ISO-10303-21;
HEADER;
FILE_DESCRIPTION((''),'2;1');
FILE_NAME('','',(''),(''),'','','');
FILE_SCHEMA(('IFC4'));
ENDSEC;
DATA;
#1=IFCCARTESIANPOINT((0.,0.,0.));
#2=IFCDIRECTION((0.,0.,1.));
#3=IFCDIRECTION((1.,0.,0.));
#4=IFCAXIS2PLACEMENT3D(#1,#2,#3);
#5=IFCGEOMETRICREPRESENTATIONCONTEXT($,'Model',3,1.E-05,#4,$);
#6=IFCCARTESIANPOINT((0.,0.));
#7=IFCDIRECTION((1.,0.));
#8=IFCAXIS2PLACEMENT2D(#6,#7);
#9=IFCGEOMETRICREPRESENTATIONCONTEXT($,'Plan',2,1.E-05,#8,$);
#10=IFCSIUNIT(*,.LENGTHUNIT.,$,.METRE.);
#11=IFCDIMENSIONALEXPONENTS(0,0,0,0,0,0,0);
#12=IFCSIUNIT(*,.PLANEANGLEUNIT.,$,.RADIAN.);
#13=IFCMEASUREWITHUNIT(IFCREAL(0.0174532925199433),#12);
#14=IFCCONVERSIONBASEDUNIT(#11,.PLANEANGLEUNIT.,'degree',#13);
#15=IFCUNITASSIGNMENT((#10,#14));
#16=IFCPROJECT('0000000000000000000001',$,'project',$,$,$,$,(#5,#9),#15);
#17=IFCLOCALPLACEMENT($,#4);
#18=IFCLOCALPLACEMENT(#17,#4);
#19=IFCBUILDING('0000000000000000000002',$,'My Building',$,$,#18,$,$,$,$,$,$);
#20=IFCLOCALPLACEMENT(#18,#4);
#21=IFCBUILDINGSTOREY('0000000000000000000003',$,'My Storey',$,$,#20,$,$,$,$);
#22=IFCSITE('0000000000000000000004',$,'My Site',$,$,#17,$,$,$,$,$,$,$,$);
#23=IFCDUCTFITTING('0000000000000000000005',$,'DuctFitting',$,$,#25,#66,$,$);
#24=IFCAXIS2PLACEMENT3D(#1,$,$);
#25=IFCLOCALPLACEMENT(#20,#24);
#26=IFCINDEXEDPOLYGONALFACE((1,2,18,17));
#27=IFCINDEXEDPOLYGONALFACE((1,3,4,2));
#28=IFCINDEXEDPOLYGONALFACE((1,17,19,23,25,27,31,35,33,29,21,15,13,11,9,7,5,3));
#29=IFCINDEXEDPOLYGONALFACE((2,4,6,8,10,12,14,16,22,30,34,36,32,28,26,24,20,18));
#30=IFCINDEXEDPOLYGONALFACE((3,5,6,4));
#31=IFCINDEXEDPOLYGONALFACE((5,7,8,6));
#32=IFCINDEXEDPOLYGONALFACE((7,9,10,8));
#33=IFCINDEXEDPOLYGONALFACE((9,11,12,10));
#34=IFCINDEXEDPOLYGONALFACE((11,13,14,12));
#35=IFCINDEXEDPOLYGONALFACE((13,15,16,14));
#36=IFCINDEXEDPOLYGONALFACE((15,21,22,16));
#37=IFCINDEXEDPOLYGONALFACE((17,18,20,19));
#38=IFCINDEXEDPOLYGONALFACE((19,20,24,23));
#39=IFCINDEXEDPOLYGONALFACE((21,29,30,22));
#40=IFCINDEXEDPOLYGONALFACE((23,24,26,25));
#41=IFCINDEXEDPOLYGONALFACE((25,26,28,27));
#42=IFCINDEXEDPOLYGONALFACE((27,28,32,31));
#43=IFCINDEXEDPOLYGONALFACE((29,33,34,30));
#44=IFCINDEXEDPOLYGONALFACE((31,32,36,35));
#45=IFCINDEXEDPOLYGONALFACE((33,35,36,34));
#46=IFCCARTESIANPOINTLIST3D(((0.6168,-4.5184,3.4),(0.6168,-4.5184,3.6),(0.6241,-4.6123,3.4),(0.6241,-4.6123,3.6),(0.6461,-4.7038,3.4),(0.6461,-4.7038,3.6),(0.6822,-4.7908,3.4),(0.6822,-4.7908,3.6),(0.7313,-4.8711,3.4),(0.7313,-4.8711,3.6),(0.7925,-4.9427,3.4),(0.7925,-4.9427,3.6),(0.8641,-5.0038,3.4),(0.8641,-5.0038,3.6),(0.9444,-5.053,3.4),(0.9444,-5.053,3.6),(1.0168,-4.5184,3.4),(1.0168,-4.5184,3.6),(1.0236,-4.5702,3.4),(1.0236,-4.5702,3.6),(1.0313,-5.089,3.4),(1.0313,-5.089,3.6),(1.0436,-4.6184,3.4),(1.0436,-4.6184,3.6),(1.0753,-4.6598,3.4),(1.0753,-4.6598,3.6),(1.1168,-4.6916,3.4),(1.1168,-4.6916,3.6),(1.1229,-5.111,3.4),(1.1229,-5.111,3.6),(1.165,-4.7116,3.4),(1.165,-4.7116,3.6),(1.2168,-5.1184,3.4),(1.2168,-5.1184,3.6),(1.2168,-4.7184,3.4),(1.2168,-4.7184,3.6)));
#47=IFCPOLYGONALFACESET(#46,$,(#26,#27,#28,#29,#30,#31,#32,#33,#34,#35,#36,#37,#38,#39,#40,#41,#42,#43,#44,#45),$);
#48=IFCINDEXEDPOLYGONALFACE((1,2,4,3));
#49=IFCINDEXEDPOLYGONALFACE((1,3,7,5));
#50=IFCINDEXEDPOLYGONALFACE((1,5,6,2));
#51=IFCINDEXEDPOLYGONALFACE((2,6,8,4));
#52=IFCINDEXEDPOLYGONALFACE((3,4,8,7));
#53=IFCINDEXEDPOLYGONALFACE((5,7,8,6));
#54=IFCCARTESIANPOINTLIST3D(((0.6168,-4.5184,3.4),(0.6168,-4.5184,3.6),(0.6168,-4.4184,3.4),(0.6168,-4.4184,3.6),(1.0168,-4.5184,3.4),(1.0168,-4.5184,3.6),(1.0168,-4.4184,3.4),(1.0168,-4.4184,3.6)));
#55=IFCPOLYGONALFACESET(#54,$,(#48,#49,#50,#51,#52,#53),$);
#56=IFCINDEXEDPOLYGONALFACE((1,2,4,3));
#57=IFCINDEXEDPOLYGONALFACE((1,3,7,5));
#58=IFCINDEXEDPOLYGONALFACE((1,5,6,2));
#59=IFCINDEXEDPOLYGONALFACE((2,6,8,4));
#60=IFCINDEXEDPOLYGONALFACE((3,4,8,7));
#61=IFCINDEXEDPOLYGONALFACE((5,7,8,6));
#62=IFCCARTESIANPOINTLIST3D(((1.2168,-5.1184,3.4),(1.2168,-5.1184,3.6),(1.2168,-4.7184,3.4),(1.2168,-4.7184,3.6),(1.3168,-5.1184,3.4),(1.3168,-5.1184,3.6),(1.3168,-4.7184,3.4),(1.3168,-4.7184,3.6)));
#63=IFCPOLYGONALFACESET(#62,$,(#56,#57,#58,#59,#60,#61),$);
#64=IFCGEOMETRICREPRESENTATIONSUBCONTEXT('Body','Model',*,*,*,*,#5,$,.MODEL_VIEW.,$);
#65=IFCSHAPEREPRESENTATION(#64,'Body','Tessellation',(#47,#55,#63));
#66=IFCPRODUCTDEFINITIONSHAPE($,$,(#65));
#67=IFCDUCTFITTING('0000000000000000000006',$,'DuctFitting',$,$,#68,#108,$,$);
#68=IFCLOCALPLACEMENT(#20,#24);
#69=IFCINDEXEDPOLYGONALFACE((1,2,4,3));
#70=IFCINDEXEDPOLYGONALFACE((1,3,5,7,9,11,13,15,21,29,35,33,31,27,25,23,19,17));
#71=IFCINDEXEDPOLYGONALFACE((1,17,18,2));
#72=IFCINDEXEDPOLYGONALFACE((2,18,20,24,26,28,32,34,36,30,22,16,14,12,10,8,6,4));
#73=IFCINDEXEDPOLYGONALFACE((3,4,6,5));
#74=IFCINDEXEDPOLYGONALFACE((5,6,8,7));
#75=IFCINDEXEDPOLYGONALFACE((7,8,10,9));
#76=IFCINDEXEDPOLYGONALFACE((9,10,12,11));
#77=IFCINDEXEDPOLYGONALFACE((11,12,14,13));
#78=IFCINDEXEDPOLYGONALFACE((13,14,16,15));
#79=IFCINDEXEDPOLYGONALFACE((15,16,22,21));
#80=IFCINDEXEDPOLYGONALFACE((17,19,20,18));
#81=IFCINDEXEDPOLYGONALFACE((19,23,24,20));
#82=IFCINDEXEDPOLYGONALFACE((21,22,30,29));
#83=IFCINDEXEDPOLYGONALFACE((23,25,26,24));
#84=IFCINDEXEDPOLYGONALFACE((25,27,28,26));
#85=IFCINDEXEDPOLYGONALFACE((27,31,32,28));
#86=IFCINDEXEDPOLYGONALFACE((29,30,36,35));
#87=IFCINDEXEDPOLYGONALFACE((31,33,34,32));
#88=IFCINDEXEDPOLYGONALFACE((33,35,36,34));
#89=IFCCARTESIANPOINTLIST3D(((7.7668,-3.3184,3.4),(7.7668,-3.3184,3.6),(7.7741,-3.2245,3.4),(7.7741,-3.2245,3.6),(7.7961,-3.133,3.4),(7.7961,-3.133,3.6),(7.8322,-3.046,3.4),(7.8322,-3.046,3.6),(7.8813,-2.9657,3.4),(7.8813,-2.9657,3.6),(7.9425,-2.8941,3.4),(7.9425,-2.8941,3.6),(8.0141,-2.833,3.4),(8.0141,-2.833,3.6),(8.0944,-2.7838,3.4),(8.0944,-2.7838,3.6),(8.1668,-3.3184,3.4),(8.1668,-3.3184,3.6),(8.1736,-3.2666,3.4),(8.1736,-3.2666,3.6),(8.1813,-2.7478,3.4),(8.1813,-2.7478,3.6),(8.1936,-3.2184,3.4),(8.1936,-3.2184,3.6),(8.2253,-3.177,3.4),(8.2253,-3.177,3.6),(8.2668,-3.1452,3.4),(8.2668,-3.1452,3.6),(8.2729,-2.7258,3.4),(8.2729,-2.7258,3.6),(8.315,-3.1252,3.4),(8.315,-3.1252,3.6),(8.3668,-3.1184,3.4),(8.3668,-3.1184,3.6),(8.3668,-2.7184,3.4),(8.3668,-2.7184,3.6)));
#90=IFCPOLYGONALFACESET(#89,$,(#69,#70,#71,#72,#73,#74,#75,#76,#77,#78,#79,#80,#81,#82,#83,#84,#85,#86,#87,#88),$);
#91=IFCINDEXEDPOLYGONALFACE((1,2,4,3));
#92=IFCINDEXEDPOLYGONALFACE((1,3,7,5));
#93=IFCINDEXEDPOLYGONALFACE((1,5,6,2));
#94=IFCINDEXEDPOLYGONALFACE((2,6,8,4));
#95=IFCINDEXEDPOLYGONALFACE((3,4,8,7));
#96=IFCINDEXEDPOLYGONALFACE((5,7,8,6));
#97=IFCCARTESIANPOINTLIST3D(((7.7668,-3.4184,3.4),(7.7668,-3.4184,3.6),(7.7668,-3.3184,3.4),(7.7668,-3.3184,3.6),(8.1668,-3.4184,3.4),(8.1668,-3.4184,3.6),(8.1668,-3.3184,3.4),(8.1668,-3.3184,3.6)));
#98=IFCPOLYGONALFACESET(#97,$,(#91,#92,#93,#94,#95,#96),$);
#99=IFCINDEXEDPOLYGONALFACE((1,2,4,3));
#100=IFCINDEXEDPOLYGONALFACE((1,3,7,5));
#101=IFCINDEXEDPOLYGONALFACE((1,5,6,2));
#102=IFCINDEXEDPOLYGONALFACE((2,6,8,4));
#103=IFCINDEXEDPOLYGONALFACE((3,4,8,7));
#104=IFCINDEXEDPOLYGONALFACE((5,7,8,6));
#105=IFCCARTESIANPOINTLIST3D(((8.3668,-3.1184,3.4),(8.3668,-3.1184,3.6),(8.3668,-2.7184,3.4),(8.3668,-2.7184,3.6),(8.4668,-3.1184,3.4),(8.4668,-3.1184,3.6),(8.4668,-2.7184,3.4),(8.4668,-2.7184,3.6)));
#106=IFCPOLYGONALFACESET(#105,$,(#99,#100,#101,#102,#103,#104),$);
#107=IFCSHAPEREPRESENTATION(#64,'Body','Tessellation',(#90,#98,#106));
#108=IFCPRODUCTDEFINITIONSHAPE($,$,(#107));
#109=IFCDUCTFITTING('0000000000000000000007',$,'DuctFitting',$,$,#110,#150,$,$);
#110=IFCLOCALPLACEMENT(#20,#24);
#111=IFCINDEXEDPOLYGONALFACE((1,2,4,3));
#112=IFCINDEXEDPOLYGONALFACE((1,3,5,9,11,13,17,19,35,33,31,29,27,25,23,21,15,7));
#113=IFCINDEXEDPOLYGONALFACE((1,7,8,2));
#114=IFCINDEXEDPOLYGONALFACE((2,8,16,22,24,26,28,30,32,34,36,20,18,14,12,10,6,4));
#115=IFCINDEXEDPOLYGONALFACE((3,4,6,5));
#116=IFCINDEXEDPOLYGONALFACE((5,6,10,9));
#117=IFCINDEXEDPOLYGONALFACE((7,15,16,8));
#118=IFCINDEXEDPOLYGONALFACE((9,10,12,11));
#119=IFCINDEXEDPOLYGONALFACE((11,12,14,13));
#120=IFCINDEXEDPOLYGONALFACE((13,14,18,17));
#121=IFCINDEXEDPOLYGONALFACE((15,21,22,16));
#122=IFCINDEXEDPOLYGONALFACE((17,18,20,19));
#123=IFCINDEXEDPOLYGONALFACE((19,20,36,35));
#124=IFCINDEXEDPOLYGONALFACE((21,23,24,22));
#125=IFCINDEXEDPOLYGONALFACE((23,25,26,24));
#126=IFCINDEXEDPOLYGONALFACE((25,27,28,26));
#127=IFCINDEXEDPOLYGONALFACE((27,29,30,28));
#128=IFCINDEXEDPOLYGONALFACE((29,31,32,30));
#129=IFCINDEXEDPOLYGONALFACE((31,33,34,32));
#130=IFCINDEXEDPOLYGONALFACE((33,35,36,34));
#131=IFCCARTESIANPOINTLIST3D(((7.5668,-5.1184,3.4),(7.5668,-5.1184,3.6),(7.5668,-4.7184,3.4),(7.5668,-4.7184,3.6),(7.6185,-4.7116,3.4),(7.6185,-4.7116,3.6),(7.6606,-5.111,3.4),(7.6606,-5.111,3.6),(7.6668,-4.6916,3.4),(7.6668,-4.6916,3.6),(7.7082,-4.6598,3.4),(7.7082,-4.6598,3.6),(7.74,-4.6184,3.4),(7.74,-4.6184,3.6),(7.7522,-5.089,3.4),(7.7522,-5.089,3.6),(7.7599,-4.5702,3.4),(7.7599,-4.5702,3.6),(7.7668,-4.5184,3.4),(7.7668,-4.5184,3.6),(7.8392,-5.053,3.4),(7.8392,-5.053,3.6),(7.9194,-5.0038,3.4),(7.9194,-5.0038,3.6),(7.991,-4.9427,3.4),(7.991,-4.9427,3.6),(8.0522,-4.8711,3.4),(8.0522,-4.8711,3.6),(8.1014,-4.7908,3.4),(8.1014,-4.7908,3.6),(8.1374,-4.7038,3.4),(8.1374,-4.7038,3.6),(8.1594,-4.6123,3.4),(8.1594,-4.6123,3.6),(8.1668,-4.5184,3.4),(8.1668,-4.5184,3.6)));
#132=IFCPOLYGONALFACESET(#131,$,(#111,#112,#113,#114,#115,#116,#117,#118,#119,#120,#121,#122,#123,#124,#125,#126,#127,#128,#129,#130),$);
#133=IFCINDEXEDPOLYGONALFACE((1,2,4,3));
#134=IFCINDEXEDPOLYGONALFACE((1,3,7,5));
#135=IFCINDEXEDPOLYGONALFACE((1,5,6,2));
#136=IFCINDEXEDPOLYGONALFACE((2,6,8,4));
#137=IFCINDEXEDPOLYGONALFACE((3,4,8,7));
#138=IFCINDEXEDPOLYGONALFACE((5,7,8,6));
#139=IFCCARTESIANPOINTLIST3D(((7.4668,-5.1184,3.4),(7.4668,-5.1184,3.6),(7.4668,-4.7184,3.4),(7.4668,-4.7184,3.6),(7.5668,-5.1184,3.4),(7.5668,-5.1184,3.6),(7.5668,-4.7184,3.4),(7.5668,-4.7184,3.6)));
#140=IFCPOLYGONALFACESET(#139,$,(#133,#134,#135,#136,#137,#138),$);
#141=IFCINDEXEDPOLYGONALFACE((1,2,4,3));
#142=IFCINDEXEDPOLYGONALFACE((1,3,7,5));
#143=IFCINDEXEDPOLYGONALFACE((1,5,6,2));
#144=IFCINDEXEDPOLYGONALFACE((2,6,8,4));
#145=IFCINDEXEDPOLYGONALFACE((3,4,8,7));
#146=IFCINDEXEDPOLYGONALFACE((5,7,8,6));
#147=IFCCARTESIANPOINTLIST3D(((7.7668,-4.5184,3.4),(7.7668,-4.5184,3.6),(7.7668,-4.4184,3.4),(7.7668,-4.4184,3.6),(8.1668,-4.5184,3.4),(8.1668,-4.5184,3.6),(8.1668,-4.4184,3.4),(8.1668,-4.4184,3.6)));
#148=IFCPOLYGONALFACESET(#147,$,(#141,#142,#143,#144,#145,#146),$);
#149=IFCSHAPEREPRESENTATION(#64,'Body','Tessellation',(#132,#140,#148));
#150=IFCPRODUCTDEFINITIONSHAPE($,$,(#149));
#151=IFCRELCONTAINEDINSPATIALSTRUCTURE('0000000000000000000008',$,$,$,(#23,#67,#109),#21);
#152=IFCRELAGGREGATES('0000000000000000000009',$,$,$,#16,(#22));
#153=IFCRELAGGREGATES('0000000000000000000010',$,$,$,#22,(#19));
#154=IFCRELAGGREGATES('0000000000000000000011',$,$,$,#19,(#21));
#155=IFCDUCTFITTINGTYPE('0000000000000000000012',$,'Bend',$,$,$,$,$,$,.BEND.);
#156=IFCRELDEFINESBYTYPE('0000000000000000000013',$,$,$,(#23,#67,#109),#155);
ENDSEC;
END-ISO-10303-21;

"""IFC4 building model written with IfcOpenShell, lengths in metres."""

from ifc_helpers import new_model, entity, si_unit, converted_unit, frame, origin_with_axes, origin_2d_with_axis, place, context, subcontext, project, spatial, line, arc, indexed_curve, rectangle, outline, extrude, source, transform, mapped, type_object, type_shapes, element, save


model = new_model("IFC4")

# Units and contexts
model_context = context("Model", 3, precision=1e-05, world=origin_with_axes())
plan_context = context("Plan", 2, precision=1e-05, world=origin_2d_with_axis())
body_context = subcontext(model_context, "Body", "Model", "MODEL_VIEW")
ifc_project = project(units=[si_unit("LENGTHUNIT", "METRE"), converted_unit("PLANEANGLEUNIT", "degree", entity("IfcReal", 0.0174532925199433), si_unit("PLANEANGLEUNIT", "RADIAN"), dimensions=[0, 0, 0, 0, 0, 0, 0])], contexts=[model_context, plan_context])

# Site, building, storey
site_placement = place(None, origin_with_axes())
site = spatial("IfcSite", under=ifc_project, at=site_placement, Name="My Site")
building_placement = place(site_placement, origin_with_axes())
building = spatial("IfcBuilding", under=site, at=building_placement, Name="My Building")
storey_placement = place(building_placement, origin_with_axes())
storey = spatial("IfcBuildingStorey", under=building, at=storey_placement, Name="My Storey")

# Duct fittings
duct_fitting_type = type_object("IfcDuctFittingType", Name="Bend", PredefinedType="BEND")
shared_shape = source(origin_with_axes(), body_context, "Body", "SweptSolid", [
    extrude(outline(indexed_curve([(-0.2, 0.0), (-0.2586, 0.1414), (-0.4, 0.2), (-0.4, 0.6), (0.0243, 0.4243), (0.2, 0.0)], segments=[arc(1, 2, 3), line(3, 4), arc(4, 5, 6), line(6, 1)])), frame((0.0, -0.1, 0.1), z_axis=(0.0, -1.0, 0.0), x_axis=(1.0, 0.0, 0.0)), (0.0, 0.0, -1.0), 0.2),
    extrude(rectangle(XDim=0.4, YDim=0.2), origin_with_axes(), (0.0, 0.0, 1.0), 0.1),
    extrude(rectangle(XDim=0.4, YDim=0.2), frame((-0.4, 0.0, 0.5), z_axis=(-1.0, 0.0, 0.0), x_axis=(0.0, 0.0, -1.0)), (0.0, 0.0, 1.0), 0.1),
])
type_shapes(duct_fitting_type, [shared_shape])
for number, where, z_axis, x_axis, name in (
    (1, (0.8168, -4.4184, 3.5), (0.0, -1.0, 0.0), (-1.0, 0.0, 0.0), "DuctFitting"),
    (2, (7.9668, -3.4184, 3.5), (0.0, 1.0, -0.000006), (-1.0, 0.0, 0.0), "DuctFitting"),
    (3, (7.4668, -4.9184, 3.5), (1.0, 0.0, 0.0), (0.0, -1.0, 0.0), "DuctFitting"),
):
    element("IfcDuctFitting", number, at=place(storey_placement, frame(where, z_axis=z_axis, x_axis=x_axis)), inside=storey, type_object=duct_fitting_type, Name=name, context=body_context, shape_type="MappedRepresentation", body=[
        mapped(shared_shape, transform((0.0, 0.0, 0.0), x_axis=(1.0, 0.0, 0.0), y_axis=(0.0, 1.0, 0.0), z_axis=(0.0, 0.0, 1.0), scale=1.0)),
    ])

save(model, "model.ifc")
